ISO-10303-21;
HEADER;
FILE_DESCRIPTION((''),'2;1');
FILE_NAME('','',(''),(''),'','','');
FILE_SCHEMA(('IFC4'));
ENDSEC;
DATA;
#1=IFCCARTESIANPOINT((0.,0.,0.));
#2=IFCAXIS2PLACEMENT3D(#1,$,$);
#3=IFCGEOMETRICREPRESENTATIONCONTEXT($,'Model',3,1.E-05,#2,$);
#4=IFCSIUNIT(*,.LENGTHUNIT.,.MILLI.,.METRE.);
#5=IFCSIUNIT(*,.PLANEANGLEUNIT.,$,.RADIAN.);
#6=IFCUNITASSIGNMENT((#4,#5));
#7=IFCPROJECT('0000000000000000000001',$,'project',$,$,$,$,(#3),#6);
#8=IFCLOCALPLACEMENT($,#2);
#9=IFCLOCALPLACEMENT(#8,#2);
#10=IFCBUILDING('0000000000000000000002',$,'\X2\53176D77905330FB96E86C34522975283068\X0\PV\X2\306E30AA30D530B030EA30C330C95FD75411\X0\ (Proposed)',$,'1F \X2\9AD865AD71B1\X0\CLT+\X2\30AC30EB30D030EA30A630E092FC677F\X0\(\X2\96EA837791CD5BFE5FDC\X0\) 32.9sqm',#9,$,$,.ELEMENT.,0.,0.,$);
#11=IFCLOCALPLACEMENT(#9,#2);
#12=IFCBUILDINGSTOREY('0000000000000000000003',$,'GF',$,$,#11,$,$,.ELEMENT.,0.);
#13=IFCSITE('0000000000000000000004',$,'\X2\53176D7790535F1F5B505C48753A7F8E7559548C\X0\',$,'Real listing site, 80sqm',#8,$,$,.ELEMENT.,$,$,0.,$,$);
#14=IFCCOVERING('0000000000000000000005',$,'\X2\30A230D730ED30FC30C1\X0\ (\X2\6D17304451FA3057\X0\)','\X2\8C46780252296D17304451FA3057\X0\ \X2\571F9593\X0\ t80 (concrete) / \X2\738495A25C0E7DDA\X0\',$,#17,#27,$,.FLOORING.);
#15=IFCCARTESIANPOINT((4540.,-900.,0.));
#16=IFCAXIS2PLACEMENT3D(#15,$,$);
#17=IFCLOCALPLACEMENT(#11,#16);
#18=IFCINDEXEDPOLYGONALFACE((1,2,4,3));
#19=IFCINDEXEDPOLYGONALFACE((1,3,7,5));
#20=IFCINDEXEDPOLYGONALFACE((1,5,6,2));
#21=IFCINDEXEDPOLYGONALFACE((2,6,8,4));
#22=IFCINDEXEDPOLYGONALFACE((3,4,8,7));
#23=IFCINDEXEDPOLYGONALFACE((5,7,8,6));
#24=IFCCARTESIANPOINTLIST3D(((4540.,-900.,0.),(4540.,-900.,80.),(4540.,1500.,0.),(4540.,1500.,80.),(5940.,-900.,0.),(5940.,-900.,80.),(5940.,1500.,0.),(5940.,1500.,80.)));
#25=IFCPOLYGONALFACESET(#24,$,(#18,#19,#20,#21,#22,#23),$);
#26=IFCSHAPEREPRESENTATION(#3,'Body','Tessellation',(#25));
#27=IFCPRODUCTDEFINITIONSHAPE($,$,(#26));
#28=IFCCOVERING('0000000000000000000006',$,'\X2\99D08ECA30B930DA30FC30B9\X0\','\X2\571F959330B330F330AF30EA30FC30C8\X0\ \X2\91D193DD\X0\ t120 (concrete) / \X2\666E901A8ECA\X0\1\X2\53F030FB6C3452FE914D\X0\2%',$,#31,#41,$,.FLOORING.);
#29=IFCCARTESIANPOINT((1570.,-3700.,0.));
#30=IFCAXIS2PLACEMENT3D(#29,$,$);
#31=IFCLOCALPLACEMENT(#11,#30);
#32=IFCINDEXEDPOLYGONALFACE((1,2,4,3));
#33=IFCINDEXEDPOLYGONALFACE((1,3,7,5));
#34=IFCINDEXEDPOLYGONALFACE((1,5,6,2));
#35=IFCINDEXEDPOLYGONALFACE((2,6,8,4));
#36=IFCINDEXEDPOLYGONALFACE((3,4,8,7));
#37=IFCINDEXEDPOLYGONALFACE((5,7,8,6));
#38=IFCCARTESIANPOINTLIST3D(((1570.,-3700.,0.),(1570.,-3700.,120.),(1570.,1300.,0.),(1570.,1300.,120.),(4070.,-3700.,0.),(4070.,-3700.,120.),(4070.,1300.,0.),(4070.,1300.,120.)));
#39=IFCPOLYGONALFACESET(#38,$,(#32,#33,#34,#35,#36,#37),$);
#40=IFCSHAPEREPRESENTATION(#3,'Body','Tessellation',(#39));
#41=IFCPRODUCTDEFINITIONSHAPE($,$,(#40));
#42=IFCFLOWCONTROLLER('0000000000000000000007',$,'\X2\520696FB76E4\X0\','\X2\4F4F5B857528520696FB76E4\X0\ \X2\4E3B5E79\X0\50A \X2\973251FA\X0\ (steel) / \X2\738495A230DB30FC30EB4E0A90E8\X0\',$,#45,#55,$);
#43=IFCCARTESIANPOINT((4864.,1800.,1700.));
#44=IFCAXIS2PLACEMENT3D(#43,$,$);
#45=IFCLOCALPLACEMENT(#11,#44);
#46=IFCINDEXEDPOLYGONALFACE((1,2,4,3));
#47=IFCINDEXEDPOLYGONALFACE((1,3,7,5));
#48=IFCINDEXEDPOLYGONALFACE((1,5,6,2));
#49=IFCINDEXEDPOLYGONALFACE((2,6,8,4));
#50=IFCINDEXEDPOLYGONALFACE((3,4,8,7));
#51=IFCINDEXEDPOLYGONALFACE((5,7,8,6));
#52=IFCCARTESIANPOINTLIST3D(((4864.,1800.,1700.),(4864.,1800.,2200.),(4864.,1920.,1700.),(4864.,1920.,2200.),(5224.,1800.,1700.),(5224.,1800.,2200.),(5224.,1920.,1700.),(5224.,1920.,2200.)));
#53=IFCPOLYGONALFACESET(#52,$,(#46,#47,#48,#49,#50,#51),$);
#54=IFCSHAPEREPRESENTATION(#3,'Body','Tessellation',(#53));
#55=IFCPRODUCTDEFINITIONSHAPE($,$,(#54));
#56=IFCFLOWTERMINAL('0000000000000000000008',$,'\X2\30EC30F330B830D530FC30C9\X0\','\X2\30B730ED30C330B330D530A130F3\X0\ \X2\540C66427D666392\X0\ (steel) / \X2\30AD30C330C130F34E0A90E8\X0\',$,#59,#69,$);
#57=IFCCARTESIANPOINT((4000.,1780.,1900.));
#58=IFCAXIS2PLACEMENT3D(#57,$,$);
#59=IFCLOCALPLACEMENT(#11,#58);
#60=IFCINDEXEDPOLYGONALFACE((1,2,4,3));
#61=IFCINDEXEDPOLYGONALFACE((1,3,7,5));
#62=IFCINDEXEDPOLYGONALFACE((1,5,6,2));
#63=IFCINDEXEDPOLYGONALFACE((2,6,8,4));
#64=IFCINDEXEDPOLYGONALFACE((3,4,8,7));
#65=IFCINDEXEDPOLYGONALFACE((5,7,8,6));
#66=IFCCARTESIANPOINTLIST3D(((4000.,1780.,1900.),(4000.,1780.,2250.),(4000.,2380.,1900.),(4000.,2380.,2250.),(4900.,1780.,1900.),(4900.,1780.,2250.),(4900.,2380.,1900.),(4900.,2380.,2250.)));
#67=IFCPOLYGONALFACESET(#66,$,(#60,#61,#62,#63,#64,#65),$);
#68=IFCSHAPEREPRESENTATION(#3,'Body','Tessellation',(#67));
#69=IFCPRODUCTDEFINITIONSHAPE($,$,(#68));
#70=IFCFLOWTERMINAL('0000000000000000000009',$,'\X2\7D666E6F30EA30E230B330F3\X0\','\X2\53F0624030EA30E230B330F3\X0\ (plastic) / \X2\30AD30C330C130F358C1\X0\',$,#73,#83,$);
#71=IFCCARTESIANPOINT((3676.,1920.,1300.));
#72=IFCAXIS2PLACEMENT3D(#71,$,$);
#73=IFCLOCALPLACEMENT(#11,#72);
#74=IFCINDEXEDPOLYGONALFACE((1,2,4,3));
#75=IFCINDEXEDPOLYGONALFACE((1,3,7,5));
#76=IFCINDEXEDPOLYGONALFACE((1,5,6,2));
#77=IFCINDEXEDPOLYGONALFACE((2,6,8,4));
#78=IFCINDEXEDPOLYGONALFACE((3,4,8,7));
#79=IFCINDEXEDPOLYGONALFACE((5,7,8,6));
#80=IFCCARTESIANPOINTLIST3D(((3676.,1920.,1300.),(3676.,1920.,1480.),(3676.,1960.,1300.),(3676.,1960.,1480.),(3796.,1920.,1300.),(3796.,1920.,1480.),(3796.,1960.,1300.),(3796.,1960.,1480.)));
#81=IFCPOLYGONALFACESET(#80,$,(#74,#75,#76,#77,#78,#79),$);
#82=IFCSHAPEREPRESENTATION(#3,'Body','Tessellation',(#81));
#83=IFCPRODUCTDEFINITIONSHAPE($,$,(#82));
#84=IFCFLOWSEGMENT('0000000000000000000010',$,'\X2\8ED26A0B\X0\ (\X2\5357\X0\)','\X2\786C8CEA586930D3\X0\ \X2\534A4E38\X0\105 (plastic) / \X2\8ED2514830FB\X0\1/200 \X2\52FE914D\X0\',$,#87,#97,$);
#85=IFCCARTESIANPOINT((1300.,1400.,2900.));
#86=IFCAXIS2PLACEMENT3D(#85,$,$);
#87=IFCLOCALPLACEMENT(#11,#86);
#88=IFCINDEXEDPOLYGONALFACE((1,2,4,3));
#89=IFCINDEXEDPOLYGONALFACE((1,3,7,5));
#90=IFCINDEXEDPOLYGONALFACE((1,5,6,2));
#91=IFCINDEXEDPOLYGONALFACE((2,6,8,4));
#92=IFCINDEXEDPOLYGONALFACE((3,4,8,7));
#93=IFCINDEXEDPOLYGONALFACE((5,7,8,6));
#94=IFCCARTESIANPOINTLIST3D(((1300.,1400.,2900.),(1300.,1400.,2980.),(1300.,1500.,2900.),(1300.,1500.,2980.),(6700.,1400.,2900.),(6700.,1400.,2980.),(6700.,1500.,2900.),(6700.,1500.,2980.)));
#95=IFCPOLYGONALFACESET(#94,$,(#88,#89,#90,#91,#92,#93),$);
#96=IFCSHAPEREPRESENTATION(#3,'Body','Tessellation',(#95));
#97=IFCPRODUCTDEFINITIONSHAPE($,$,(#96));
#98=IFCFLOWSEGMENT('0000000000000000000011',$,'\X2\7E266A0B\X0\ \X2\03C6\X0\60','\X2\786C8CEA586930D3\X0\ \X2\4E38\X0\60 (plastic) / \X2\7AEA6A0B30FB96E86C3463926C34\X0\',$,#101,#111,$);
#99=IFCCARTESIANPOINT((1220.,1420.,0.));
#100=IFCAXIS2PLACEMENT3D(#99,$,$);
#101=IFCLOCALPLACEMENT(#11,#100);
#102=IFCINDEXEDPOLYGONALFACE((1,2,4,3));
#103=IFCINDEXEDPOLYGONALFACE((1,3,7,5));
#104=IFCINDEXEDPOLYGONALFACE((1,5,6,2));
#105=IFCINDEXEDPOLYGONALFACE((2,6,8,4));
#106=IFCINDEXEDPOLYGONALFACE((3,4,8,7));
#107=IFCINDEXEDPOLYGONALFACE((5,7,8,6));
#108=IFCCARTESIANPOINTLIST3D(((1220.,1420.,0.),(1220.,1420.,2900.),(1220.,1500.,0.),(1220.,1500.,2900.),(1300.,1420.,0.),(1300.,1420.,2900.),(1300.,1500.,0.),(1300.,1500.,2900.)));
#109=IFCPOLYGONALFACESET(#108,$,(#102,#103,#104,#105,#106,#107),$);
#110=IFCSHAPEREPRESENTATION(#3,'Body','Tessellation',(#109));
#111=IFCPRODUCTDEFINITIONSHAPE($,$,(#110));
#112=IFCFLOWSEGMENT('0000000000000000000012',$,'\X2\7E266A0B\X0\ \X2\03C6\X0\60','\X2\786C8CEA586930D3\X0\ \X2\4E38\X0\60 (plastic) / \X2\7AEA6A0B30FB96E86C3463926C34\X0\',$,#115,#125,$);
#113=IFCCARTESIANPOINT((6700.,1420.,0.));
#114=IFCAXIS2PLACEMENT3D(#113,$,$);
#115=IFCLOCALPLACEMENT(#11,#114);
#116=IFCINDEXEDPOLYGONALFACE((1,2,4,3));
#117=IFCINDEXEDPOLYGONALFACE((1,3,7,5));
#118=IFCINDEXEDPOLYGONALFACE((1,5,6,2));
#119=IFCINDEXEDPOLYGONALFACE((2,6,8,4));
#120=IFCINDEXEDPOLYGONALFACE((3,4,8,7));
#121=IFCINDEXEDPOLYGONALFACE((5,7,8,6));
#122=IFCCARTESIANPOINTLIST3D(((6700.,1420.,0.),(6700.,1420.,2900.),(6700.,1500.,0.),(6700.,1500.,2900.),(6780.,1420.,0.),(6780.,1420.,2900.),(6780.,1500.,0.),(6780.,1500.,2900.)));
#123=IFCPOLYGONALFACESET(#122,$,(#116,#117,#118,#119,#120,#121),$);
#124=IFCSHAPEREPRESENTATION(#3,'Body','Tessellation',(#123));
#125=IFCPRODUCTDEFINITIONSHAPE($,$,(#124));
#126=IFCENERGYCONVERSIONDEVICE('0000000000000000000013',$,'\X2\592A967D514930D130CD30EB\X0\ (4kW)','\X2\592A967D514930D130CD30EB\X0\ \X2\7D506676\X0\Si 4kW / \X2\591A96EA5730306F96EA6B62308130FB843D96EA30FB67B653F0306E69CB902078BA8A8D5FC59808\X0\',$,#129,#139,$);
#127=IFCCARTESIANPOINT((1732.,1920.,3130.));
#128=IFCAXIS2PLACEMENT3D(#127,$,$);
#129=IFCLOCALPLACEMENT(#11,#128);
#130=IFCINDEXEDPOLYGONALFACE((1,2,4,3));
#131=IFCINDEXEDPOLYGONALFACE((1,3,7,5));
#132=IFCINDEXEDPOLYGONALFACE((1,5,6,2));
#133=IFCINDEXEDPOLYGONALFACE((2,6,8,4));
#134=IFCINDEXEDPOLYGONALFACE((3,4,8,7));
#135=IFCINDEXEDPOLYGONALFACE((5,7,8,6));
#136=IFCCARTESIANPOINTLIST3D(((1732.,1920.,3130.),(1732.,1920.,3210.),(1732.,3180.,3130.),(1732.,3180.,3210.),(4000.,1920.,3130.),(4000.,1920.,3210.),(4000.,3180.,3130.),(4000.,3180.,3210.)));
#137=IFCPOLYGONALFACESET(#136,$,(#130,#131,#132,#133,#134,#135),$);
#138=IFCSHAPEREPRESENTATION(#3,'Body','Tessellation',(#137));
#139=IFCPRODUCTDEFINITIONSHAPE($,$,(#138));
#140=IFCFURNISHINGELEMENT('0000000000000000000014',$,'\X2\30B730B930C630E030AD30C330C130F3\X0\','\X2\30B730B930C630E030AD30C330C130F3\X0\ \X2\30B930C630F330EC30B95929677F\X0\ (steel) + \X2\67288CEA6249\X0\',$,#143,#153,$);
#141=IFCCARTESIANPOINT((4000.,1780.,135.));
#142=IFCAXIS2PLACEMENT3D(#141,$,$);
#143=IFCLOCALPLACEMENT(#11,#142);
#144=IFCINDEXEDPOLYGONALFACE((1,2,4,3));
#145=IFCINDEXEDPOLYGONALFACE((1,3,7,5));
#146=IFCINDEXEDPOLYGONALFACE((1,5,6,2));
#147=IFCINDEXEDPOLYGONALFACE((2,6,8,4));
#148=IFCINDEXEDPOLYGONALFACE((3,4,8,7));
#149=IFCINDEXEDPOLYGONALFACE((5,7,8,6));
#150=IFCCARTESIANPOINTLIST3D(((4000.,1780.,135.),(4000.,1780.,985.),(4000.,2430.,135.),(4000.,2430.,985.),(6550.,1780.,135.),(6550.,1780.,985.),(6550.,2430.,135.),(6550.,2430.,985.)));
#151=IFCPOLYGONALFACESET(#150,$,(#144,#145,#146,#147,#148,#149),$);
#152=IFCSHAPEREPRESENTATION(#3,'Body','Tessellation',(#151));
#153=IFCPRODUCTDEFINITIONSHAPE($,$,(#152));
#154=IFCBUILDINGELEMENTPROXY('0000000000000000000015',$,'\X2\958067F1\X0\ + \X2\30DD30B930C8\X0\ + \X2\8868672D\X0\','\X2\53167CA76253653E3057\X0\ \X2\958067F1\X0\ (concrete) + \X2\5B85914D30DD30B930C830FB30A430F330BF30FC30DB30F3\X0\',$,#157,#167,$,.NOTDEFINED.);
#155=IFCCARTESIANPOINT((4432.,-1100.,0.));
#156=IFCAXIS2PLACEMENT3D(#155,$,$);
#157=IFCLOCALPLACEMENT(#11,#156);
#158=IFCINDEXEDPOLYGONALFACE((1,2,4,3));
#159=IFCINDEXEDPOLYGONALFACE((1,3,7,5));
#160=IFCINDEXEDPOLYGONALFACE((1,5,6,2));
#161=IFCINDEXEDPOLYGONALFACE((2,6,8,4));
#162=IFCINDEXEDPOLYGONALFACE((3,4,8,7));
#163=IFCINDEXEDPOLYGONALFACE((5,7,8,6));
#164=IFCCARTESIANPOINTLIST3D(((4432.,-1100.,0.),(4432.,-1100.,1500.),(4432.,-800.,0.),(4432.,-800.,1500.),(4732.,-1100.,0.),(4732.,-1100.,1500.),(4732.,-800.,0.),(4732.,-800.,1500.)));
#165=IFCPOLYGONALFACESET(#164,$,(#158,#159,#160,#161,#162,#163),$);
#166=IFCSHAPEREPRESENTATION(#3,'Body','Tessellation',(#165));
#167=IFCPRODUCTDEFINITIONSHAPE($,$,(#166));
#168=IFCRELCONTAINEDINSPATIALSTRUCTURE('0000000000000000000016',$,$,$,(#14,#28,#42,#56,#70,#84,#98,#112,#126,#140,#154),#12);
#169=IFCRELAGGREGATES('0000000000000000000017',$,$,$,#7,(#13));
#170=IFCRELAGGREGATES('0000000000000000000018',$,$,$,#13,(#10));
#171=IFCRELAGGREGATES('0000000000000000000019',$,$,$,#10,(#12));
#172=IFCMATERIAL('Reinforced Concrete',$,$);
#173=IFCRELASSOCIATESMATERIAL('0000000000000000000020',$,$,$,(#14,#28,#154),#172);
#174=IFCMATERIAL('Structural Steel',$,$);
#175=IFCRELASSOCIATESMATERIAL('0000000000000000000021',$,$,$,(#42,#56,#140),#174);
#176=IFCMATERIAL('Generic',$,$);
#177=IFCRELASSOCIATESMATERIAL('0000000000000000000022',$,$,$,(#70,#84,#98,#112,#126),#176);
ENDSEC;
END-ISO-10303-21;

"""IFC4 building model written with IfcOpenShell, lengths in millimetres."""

from ifc_helpers import new_model, si_unit, frame, frame_2d, origin, place, context, project, spatial, rectangle, extrude, material, element, save


model = new_model("IFC4")

# Units and contexts
model_context = context("Model", 3, precision=1e-05, world=origin())
ifc_project = project(units=[si_unit("LENGTHUNIT", "METRE", prefix="MILLI"), si_unit("PLANEANGLEUNIT", "RADIAN")], contexts=[model_context])

# Site, building, storey
site_placement = place(None, origin())
site = spatial("IfcSite", under=ifc_project, at=site_placement, Name="北海道弟子屈町美留和", ObjectType="Real listing site, 80sqm", CompositionType="ELEMENT", RefElevation=0.0)
building_placement = place(site_placement, origin())
building = spatial("IfcBuilding", under=site, at=building_placement, Name="北海道・雨水利用とPVのオフグリッド志向 (Proposed)", ObjectType="1F 高断熱CLT+ガルバリウム鋼板(雪荷重対応) 32.9sqm", CompositionType="ELEMENT", ElevationOfRefHeight=0.0, ElevationOfTerrain=0.0)
storey_placement = place(building_placement, origin())
storey = spatial("IfcBuildingStorey", under=building, at=storey_placement, Name="GF", CompositionType="ELEMENT", Elevation=0.0)

# Shared definitions
ifc_material_1 = material(Name="Reinforced Concrete")

# Shared definitions
ifc_material_2 = material(Name="Structural Steel")

# Coverings
ifc_material_3 = material(Name="Generic")
covering_1_placement = place(storey_placement, frame((4540.0, -900.0, 0.0)))
element("IfcCovering", 1, at=covering_1_placement, inside=storey, material=ifc_material_1, Name="アプローチ (洗い出し)", Description="豆砂利洗い出し 土間 t80 (concrete) / 玄関導線", PredefinedType="FLOORING", context=model_context, shape_type="SweptSolid", body=[
    extrude(rectangle(XDim=1400.0, YDim=2400.0, at=frame_2d((700.0, 1200.0))), frame((4540.0, -900.0, 0.0)), (0.0, 0.0, 1.0), 80.0),
])
covering_2_placement = place(storey_placement, frame((1570.0, -3700.0, 0.0)))
element("IfcCovering", 2, at=covering_2_placement, inside=storey, material=ifc_material_1, Name="駐車スペース", Description="土間コンクリート 金鏝 t120 (concrete) / 普通車1台・水勾配2%", PredefinedType="FLOORING", context=model_context, shape_type="SweptSolid", body=[
    extrude(rectangle(XDim=2500.0, YDim=5000.0, at=frame_2d((1250.0, 2500.0))), frame((1570.0, -3700.0, 0.0)), (0.0, 0.0, 1.0), 120.0),
])

# Flow controller
flow_controller_placement = place(storey_placement, frame((4864.0, 1800.0, 1700.0)))
element("IfcFlowController", 3, at=flow_controller_placement, inside=storey, material=ifc_material_2, Name="分電盤", Description="住宅用分電盤 主幹50A 露出 (steel) / 玄関ホール上部", context=model_context, shape_type="SweptSolid", body=[
    extrude(rectangle(XDim=360.0, YDim=120.0, at=frame_2d((180.0, 60.0))), frame((4864.0, 1800.0, 1700.0)), (0.0, 0.0, 1.0), 500.0),
])

# Flow terminals
flow_terminal_1_placement = place(storey_placement, frame((4000.0, 1780.0, 1900.0)))
element("IfcFlowTerminal", 4, at=flow_terminal_1_placement, inside=storey, material=ifc_material_2, Name="レンジフード", Description="シロッコファン 同時給排 (steel) / キッチン上部", context=model_context, shape_type="SweptSolid", body=[
    extrude(rectangle(XDim=900.0, YDim=600.0, at=frame_2d((450.0, 300.0))), frame((4000.0, 1780.0, 1900.0)), (0.0, 0.0, 1.0), 350.0),
])
flow_terminal_2_placement = place(storey_placement, frame((3676.0, 1920.0, 1300.0)))
element("IfcFlowTerminal", 5, at=flow_terminal_2_placement, inside=storey, material=ifc_material_3, Name="給湯リモコン", Description="台所リモコン (plastic) / キッチン壁", context=model_context, shape_type="SweptSolid", body=[
    extrude(rectangle(XDim=120.0, YDim=40.0, at=frame_2d((60.0, 20.0))), frame((3676.0, 1920.0, 1300.0)), (0.0, 0.0, 1.0), 180.0),
])

# Flow segments
flow_segment_1_placement = place(storey_placement, frame((1300.0, 1400.0, 2900.0)))
element("IfcFlowSegment", 6, at=flow_segment_1_placement, inside=storey, material=ifc_material_3, Name="軒樋 (南)", Description="硬質塩ビ 半丸105 (plastic) / 軒先・1/200 勾配", context=model_context, shape_type="SweptSolid", body=[
    extrude(rectangle(XDim=5400.0, YDim=100.0, at=frame_2d((2700.0, 50.0))), frame((1300.0, 1400.0, 2900.0)), (0.0, 0.0, 1.0), 80.0),
])
flow_segment_2_placement = place(storey_placement, frame((1220.0, 1420.0, 0.0)))
element("IfcFlowSegment", 7, at=flow_segment_2_placement, inside=storey, material=ifc_material_3, Name="縦樋 φ60", Description="硬質塩ビ 丸60 (plastic) / 竪樋・雨水排水", context=model_context, shape_type="SweptSolid", body=[
    extrude(rectangle(XDim=80.0, YDim=80.0, at=frame_2d((40.0, 40.0))), frame((1220.0, 1420.0, 0.0)), (0.0, 0.0, 1.0), 2900.0),
])
flow_segment_3_placement = place(storey_placement, frame((6700.0, 1420.0, 0.0)))
element("IfcFlowSegment", 8, at=flow_segment_3_placement, inside=storey, material=ifc_material_3, Name="縦樋 φ60", Description="硬質塩ビ 丸60 (plastic) / 竪樋・雨水排水", context=model_context, shape_type="SweptSolid", body=[
    extrude(rectangle(XDim=80.0, YDim=80.0, at=frame_2d((40.0, 40.0))), frame((6700.0, 1420.0, 0.0)), (0.0, 0.0, 1.0), 2900.0),
])

# Energy conversion device
energy_conversion_device_placement = place(storey_placement, frame((1732.0, 1920.0, 3130.0)))
element("IfcEnergyConversionDevice", 9, at=energy_conversion_device_placement, inside=storey, material=ifc_material_3, Name="太陽光パネル (4kW)", Description="太陽光パネル 結晶Si 4kW / 多雪地は雪止め・落雪・架台の構造確認必須", context=model_context, shape_type="SweptSolid", body=[
    extrude(rectangle(XDim=2268.0, YDim=1260.0, at=frame_2d((1134.0, 630.0))), frame((1732.0, 1920.0, 3130.0)), (0.0, 0.0, 1.0), 80.0),
])

# Furnishing element
furnishing_placement = place(storey_placement, frame((4000.0, 1780.0, 135.0)))
element("IfcFurnishingElement", 10, at=furnishing_placement, inside=storey, material=ifc_material_2, Name="システムキッチン", Description="システムキッチン ステンレス天板 (steel) + 木質扉", context=model_context, shape_type="SweptSolid", body=[
    extrude(rectangle(XDim=2550.0, YDim=650.0, at=frame_2d((1275.0, 325.0))), frame((4000.0, 1780.0, 135.0)), (0.0, 0.0, 1.0), 850.0),
])

# Building element proxy
proxy_placement = place(storey_placement, frame((4432.0, -1100.0, 0.0)))
element("IfcBuildingElementProxy", 11, at=proxy_placement, inside=storey, material=ifc_material_1, Name="門柱 + ポスト + 表札", Description="化粧打放し 門柱 (concrete) + 宅配ポスト・インターホン", PredefinedType="NOTDEFINED", context=model_context, shape_type="SweptSolid", body=[
    extrude(rectangle(XDim=300.0, YDim=300.0, at=frame_2d((150.0, 150.0))), frame((4432.0, -1100.0, 0.0)), (0.0, 0.0, 1.0), 1500.0),
])

save(model, "model.ifc")
